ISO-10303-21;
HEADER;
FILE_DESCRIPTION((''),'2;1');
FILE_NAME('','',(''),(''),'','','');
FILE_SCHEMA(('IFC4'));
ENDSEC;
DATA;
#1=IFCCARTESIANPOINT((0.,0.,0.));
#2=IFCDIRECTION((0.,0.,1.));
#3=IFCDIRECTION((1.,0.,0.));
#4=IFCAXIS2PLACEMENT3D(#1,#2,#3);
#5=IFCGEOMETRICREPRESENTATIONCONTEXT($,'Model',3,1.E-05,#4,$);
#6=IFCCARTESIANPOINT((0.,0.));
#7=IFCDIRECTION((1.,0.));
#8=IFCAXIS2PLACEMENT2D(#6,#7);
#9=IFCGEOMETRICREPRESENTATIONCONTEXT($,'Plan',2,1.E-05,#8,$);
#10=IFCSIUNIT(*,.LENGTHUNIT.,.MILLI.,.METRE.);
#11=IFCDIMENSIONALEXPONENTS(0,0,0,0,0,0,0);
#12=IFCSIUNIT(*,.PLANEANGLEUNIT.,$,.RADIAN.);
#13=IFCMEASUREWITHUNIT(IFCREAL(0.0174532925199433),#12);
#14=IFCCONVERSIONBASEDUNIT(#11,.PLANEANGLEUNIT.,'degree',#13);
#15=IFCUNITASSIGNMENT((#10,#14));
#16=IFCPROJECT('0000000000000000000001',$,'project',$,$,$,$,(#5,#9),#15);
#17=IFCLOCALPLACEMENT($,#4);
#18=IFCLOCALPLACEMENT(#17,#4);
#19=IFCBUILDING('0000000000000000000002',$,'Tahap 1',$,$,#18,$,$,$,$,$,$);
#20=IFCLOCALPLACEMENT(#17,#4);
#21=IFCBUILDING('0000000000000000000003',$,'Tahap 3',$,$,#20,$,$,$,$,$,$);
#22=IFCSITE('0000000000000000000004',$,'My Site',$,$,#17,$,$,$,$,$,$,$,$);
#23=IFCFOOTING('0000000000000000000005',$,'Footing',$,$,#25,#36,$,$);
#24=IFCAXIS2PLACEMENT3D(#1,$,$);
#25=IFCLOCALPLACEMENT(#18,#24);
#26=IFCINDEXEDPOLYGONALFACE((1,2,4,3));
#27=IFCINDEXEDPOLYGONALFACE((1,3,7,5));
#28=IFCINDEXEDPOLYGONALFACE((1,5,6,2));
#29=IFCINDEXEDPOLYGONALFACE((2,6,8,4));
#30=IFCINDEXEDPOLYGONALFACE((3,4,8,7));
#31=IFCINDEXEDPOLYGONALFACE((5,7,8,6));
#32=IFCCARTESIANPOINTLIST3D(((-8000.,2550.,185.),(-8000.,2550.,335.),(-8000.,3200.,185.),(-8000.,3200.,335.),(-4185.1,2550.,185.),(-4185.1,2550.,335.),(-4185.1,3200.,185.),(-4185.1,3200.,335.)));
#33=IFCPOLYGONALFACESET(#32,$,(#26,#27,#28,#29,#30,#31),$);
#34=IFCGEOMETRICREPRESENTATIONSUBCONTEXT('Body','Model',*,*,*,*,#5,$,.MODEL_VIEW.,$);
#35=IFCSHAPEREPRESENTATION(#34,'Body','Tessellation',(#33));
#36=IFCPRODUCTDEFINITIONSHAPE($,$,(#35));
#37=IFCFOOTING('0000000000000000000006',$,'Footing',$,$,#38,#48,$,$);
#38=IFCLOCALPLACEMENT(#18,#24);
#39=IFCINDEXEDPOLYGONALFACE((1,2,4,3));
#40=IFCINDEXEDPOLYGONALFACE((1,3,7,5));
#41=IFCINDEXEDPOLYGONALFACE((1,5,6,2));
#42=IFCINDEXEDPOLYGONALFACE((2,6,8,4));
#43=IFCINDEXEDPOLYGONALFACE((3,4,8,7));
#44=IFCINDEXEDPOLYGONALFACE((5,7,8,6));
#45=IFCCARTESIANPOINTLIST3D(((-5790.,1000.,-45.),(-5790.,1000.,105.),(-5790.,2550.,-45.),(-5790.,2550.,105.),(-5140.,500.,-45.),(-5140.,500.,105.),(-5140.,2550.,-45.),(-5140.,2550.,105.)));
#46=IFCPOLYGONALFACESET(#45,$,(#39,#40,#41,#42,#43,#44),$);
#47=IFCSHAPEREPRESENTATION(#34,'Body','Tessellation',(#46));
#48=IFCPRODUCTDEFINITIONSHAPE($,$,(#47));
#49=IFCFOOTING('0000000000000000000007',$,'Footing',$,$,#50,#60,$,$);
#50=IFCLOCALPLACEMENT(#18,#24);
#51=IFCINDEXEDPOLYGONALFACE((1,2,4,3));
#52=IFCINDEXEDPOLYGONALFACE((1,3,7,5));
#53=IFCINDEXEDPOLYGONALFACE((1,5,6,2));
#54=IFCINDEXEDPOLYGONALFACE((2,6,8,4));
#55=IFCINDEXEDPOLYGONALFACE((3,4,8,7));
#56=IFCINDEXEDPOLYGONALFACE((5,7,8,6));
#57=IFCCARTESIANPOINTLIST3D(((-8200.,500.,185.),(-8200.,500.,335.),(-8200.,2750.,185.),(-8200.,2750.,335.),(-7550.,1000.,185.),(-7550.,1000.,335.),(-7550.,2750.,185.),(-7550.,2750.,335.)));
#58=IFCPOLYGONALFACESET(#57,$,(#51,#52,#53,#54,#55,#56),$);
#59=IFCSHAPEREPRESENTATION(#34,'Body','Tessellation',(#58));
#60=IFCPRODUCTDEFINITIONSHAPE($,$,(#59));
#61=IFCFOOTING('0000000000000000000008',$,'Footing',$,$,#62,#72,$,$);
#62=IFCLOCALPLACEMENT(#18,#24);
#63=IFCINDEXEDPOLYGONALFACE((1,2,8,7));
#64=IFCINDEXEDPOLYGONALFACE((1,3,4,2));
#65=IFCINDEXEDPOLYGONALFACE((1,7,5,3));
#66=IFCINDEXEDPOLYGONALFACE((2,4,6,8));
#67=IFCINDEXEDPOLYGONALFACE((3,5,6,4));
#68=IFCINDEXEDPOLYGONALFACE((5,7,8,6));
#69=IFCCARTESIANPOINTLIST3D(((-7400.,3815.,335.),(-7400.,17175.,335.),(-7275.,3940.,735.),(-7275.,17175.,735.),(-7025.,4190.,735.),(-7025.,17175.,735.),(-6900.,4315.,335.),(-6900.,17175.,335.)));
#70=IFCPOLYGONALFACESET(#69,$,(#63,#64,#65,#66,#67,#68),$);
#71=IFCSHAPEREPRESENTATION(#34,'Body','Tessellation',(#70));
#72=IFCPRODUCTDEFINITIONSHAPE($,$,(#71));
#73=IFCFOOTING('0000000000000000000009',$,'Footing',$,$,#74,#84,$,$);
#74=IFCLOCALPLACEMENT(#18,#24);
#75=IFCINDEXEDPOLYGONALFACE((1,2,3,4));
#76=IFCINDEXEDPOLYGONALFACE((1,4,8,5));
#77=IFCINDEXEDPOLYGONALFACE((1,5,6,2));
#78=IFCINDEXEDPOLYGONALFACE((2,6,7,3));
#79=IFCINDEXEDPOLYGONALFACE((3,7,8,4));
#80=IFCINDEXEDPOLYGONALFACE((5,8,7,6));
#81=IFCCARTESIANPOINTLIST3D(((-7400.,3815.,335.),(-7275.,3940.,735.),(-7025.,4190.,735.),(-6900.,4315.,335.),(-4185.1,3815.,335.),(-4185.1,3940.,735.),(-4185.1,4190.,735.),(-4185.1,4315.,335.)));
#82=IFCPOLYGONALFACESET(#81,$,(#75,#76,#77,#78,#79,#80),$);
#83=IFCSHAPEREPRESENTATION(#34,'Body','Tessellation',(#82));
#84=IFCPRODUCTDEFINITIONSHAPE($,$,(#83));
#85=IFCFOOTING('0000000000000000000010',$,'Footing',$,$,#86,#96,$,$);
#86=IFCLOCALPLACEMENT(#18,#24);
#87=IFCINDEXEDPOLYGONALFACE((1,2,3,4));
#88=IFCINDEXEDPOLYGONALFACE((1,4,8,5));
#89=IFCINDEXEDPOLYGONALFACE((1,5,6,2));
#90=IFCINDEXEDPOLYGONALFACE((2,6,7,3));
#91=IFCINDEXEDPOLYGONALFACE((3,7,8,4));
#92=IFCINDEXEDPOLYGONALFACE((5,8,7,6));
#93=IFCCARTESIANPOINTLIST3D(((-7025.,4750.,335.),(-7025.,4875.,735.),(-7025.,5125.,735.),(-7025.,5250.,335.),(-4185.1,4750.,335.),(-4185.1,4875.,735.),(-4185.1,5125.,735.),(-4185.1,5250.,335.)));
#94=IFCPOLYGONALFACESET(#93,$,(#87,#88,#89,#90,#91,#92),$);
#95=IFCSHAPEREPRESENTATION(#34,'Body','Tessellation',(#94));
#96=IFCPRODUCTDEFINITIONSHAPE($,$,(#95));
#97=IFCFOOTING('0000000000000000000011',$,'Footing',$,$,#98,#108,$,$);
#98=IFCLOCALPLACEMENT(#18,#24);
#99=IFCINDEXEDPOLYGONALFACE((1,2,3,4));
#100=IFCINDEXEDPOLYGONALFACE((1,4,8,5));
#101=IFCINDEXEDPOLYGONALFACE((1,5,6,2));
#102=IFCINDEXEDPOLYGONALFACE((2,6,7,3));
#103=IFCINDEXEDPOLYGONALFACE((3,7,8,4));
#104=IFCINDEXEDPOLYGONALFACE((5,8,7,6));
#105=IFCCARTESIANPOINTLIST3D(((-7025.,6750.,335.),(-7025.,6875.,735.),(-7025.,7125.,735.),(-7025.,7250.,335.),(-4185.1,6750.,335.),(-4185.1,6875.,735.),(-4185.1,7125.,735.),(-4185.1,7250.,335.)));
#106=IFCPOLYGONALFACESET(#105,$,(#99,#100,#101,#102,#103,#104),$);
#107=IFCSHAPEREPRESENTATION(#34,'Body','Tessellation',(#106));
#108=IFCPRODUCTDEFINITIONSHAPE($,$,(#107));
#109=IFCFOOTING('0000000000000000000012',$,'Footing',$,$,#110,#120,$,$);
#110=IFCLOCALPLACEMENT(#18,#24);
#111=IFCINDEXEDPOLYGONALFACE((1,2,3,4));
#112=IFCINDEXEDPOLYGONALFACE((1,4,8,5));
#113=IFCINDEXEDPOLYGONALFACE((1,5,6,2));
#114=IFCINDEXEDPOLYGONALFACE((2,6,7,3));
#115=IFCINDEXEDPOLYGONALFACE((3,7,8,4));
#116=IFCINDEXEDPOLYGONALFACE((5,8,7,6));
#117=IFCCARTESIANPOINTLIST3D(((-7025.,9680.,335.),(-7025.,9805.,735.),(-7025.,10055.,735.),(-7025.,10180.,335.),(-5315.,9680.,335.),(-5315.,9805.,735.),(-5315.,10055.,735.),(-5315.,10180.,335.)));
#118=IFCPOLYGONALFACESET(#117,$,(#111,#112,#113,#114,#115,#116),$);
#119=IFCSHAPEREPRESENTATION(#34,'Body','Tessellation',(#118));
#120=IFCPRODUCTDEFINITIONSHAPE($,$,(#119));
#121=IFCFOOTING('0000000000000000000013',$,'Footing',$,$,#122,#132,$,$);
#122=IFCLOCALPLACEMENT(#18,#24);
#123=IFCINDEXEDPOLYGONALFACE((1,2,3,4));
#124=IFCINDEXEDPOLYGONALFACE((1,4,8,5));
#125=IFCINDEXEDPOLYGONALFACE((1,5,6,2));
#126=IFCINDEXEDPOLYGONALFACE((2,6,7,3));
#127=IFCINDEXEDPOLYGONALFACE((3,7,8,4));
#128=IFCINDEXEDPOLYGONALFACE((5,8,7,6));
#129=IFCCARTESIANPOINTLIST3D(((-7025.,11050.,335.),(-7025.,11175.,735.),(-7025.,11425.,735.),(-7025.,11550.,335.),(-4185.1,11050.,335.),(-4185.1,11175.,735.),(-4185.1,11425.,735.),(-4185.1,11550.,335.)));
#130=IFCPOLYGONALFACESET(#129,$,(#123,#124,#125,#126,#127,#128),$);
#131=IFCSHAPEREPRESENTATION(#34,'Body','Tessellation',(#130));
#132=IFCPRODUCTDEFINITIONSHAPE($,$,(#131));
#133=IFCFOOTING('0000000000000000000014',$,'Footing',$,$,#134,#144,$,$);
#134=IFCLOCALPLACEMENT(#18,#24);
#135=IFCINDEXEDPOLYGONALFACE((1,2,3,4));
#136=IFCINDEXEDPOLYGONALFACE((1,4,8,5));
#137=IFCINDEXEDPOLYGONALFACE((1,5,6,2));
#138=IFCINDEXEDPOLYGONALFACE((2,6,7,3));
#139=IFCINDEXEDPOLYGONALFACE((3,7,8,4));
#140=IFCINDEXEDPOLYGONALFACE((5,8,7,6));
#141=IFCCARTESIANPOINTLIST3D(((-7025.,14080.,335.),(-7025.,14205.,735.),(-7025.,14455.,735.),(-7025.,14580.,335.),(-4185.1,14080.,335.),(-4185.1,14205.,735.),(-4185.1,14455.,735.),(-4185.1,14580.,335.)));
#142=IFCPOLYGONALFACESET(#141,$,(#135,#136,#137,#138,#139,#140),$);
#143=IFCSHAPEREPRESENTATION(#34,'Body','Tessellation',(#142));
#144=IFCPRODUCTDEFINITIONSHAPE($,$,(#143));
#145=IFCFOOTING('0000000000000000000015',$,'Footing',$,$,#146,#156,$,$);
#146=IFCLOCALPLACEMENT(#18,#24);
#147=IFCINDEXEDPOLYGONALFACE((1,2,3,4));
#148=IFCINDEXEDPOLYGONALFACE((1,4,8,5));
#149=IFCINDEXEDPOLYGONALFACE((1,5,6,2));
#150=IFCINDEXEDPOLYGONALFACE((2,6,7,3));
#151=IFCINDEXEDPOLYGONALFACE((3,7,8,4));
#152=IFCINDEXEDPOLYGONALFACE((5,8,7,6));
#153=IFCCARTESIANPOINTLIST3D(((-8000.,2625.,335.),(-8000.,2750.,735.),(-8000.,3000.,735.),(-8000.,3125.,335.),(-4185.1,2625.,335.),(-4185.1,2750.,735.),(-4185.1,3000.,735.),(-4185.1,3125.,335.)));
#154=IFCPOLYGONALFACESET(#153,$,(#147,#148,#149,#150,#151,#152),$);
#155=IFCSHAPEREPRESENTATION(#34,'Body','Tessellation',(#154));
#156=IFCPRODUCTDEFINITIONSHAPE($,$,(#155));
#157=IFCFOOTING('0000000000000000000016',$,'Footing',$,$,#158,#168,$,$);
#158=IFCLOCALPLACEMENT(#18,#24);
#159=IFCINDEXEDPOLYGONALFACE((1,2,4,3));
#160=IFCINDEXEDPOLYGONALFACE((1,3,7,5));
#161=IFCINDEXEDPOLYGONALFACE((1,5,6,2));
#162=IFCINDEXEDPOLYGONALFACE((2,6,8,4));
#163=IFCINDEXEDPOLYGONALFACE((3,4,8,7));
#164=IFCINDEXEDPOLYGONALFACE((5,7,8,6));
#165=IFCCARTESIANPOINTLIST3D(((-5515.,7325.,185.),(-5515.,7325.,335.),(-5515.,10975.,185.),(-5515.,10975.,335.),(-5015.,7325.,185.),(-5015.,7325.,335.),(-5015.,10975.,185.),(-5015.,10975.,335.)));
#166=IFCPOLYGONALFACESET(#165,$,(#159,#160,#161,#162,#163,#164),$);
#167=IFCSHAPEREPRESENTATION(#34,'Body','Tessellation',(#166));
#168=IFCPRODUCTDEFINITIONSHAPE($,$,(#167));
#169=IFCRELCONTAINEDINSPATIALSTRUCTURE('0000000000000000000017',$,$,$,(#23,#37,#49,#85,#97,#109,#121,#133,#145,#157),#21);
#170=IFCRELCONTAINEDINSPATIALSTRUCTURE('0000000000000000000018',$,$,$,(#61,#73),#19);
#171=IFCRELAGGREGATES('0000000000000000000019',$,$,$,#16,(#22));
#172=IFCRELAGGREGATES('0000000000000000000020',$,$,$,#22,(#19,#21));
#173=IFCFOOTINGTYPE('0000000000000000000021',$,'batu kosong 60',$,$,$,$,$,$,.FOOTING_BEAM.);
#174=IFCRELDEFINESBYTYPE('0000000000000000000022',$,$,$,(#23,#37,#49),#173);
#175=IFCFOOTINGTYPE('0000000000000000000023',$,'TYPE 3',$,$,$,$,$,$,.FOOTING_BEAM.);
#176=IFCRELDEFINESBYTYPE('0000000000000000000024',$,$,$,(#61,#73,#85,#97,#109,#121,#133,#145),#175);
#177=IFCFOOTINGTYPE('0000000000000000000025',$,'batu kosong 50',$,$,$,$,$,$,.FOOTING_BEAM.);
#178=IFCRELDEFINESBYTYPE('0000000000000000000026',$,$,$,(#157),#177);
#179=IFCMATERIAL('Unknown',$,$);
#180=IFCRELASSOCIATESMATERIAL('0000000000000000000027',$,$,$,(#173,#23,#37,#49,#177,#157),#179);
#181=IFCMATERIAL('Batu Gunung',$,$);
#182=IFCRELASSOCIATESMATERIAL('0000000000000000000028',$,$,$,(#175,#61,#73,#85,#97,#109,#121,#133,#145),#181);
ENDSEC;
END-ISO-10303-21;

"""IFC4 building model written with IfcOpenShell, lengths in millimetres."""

from ifc_helpers import new_model, entity, si_unit, converted_unit, frame, origin_with_axes, origin_2d_with_axis, place, context, subcontext, project, spatial, indexed_curve, rectangle, outline, extrude, clip, halfspace, material, material_profile, profile_set, profile_usage, type_object, element, save


model = new_model("IFC4")

# Units and contexts
model_context = context("Model", 3, precision=1e-05, world=origin_with_axes())
plan_context = context("Plan", 2, precision=1e-05, world=origin_2d_with_axis())
body_context = subcontext(model_context, "Body", "Model", "MODEL_VIEW")
ifc_project = project(units=[si_unit("LENGTHUNIT", "METRE", prefix="MILLI"), converted_unit("PLANEANGLEUNIT", "degree", entity("IfcReal", 0.0174532925199433), si_unit("PLANEANGLEUNIT", "RADIAN"), dimensions=[0, 0, 0, 0, 0, 0, 0])], contexts=[model_context, plan_context])

# Site, building
site_placement = place(None, origin_with_axes())
site = spatial("IfcSite", under=ifc_project, at=site_placement, Name="My Site")
building_1_placement = place(site_placement, origin_with_axes())
building_1 = spatial("IfcBuilding", under=site, at=building_1_placement, Name="Tahap 1")

# Shared definitions
ifc_material_1 = material(Name="Batu Gunung")

# Shared definitions
building_2_placement = place(site_placement, origin_with_axes())
building_2 = spatial("IfcBuilding", under=site, at=building_2_placement, Name="Tahap 3")

# Footings
ifc_material_2 = material(Name="Unknown")
ifc_material_profile_1 = material_profile(ifc_material_2, rectangle(XDim=650.0, YDim=150.0, kind="CURVE"))
ifc_profile_set_1 = profile_set([ifc_material_profile_1])
footing_type_1 = type_object("IfcFootingType", Name="batu kosong 60", PredefinedType="FOOTING_BEAM", material=ifc_profile_set_1)
ifc_profile_usage_1 = profile_usage(ifc_profile_set_1, cardinal=8)
footing_1_placement = place(building_2_placement, frame((-8000.0, 2875.0, 335.0), z_axis=(1.0, 0.0, 0.0), x_axis=(0.0, 1.0, 0.0)))
element("IfcFooting", 1, at=footing_1_placement, inside=building_2, type_object=footing_type_1, material=ifc_profile_usage_1, Name="Footing", context=body_context, shape_type="SweptSolid", body=[
    extrude(rectangle(XDim=650.0, YDim=150.0, kind="CURVE"), frame((0.0, -75.0, 0.0), z_axis=(0.0, 0.0, 1.0), x_axis=(1.0, 0.0, 0.0)), (0.0, 0.0, 1.0), 3814.9),
])
ifc_profile_usage_2 = profile_usage(ifc_profile_set_1, cardinal=8)
footing_2_placement = place(building_2_placement, frame((-5465.0, 500.0, 105.0), z_axis=(0.000001, 1.0, 0.0), x_axis=(-1.0, 0.000001, 0.0)))
element("IfcFooting", 2, at=footing_2_placement, inside=building_2, type_object=footing_type_1, material=ifc_profile_usage_2, Name="Footing", context=body_context, shape_type="Clipping", body=[
    clip(extrude(rectangle(XDim=650.0, YDim=150.0, kind="CURVE"), frame((0.0, -75.0, 0.0), z_axis=(0.0, 0.0, 1.0), x_axis=(1.0, 0.0, 0.0)), (0.0, 0.0, 1.0), 2050.0), halfspace(frame((-325.0, -105.0, 0.0), z_axis=(0.60971, 0.0, -0.792624), x_axis=(0.0, -1.0, 0.0)), False)),
])
ifc_profile_usage_3 = profile_usage(ifc_profile_set_1, cardinal=8)
footing_3_placement = place(building_2_placement, frame((-7875.0, 2750.0, 335.0), z_axis=(0.0, -1.0, 0.0), x_axis=(1.0, 0.0, 0.0)))
element("IfcFooting", 3, at=footing_3_placement, inside=building_2, type_object=footing_type_1, material=ifc_profile_usage_3, Name="Footing", context=body_context, shape_type="Clipping", body=[
    clip(extrude(rectangle(XDim=650.0, YDim=150.0, kind="CURVE"), frame((0.0, -75.0, 0.0), z_axis=(0.0, 0.0, 1.0), x_axis=(1.0, 0.0, 0.0)), (0.0, 0.0, 1.0), 2250.0), halfspace(frame((-325.0, -335.0, 2250.0), z_axis=(0.609712, 0.0, 0.792623), x_axis=(0.0, -1.0, 0.0)), False)),
])
ifc_material_profile_2 = material_profile(ifc_material_1, outline(indexed_curve([(-125.0, 0.0), (125.0, 0.0), (250.0, -400.0), (-250.0, -400.0), (-125.0, 0.0)])))
ifc_profile_set_2 = profile_set([ifc_material_profile_2])
ifc_profile_usage_4 = profile_usage(ifc_profile_set_2)
footing_type_2 = type_object("IfcFootingType", Name="TYPE 3", PredefinedType="FOOTING_BEAM", material=ifc_profile_set_2)
footing_4_placement = place(building_1_placement, frame((-7150.0, 3815.0, 735.0), z_axis=(0.0, 1.0, 0.0), x_axis=(-1.0, 0.0, 0.0)))
element("IfcFooting", 4, at=footing_4_placement, inside=building_1, type_object=footing_type_2, material=ifc_profile_usage_4, Name="Footing", context=body_context, shape_type="Clipping", body=[
    clip(extrude(outline(indexed_curve([(-125.0, 0.0), (125.0, 0.0), (250.0, -400.0), (-250.0, -400.0), (-125.0, 0.0)])), origin_with_axes(), (0.0, 0.0, 1.0), 13360.0), halfspace(frame((250.0, -735.0, 0.0), z_axis=(-0.707106, 0.0, -0.707107), x_axis=(0.0, 1.0, 0.0)), False)),
])
ifc_profile_usage_5 = profile_usage(ifc_profile_set_2)
footing_5_placement = place(building_1_placement, frame((-7400.0, 4065.0, 735.0), z_axis=(1.0, 0.0, 0.0), x_axis=(0.0, 1.0, 0.0)))
element("IfcFooting", 5, at=footing_5_placement, inside=building_1, type_object=footing_type_2, material=ifc_profile_usage_5, Name="Footing", context=body_context, shape_type="Clipping", body=[
    clip(extrude(outline(indexed_curve([(-125.0, 0.0), (125.0, 0.0), (250.0, -400.0), (-250.0, -400.0), (-125.0, 0.0)])), origin_with_axes(), (0.0, 0.0, 1.0), 3214.9), halfspace(frame((-250.0, -735.0, 0.0), z_axis=(0.707107, 0.0, -0.707106), x_axis=(0.0, -1.0, 0.0)), False)),
])
ifc_profile_usage_6 = profile_usage(ifc_profile_set_2)
footing_6_placement = place(building_2_placement, frame((-7025.0, 5000.0, 735.0), z_axis=(1.0, 0.0, 0.0), x_axis=(0.0, 1.0, 0.0)))
element("IfcFooting", 6, at=footing_6_placement, inside=building_2, type_object=footing_type_2, material=ifc_profile_usage_6, Name="Footing", context=body_context, shape_type="SweptSolid", body=[
    extrude(outline(indexed_curve([(-125.0, 0.0), (125.0, 0.0), (250.0, -400.0), (-250.0, -400.0), (-125.0, 0.0)])), origin_with_axes(), (0.0, 0.0, 1.0), 2839.9),
])
ifc_profile_usage_7 = profile_usage(ifc_profile_set_2)
footing_7_placement = place(building_2_placement, frame((-7025.0, 7000.0, 735.0), z_axis=(1.0, 0.0, 0.0), x_axis=(0.0, 1.0, 0.0)))
element("IfcFooting", 7, at=footing_7_placement, inside=building_2, type_object=footing_type_2, material=ifc_profile_usage_7, Name="Footing", context=body_context, shape_type="SweptSolid", body=[
    extrude(outline(indexed_curve([(-125.0, 0.0), (125.0, 0.0), (250.0, -400.0), (-250.0, -400.0), (-125.0, 0.0)])), origin_with_axes(), (0.0, 0.0, 1.0), 2839.9),
])
ifc_profile_usage_8 = profile_usage(ifc_profile_set_2)
footing_8_placement = place(building_2_placement, frame((-7025.0, 9930.0, 735.0), z_axis=(1.0, 0.0, 0.0), x_axis=(0.0, 1.0, 0.0)))
element("IfcFooting", 8, at=footing_8_placement, inside=building_2, type_object=footing_type_2, material=ifc_profile_usage_8, Name="Footing", context=body_context, shape_type="SweptSolid", body=[
    extrude(outline(indexed_curve([(-125.0, 0.0), (125.0, 0.0), (250.0, -400.0), (-250.0, -400.0), (-125.0, 0.0)])), origin_with_axes(), (0.0, 0.0, 1.0), 1710.0),
])
ifc_profile_usage_9 = profile_usage(ifc_profile_set_2)
footing_9_placement = place(building_2_placement, frame((-7025.0, 11300.0, 735.0), z_axis=(1.0, 0.0, 0.0), x_axis=(0.0, 1.0, 0.0)))
element("IfcFooting", 9, at=footing_9_placement, inside=building_2, type_object=footing_type_2, material=ifc_profile_usage_9, Name="Footing", context=body_context, shape_type="SweptSolid", body=[
    extrude(outline(indexed_curve([(-125.0, 0.0), (125.0, 0.0), (250.0, -400.0), (-250.0, -400.0), (-125.0, 0.0)])), origin_with_axes(), (0.0, 0.0, 1.0), 2839.9),
])
ifc_profile_usage_10 = profile_usage(ifc_profile_set_2)
footing_10_placement = place(building_2_placement, frame((-7025.0, 14330.0, 735.0), z_axis=(1.0, 0.0, 0.0), x_axis=(0.0, 1.0, 0.0)))
element("IfcFooting", 10, at=footing_10_placement, inside=building_2, type_object=footing_type_2, material=ifc_profile_usage_10, Name="Footing", context=body_context, shape_type="SweptSolid", body=[
    extrude(outline(indexed_curve([(-125.0, 0.0), (125.0, 0.0), (250.0, -400.0), (-250.0, -400.0), (-125.0, 0.0)])), origin_with_axes(), (0.0, 0.0, 1.0), 2839.9),
])
ifc_profile_usage_11 = profile_usage(ifc_profile_set_2)
footing_11_placement = place(building_2_placement, frame((-8000.0, 2875.0, 735.0), z_axis=(1.0, 0.0, 0.0), x_axis=(0.0, 1.0, 0.0)))
element("IfcFooting", 11, at=footing_11_placement, inside=building_2, type_object=footing_type_2, material=ifc_profile_usage_11, Name="Footing", context=body_context, shape_type="SweptSolid", body=[
    extrude(outline(indexed_curve([(-125.0, 0.0), (125.0, 0.0), (250.0, -400.0), (-250.0, -400.0), (-125.0, 0.0)])), origin_with_axes(), (0.0, 0.0, 1.0), 3814.9),
])
ifc_material_profile_3 = material_profile(ifc_material_2, rectangle(XDim=500.0, YDim=150.0, kind="CURVE"))
ifc_profile_set_3 = profile_set([ifc_material_profile_3])
ifc_profile_usage_12 = profile_usage(ifc_profile_set_3)
footing_type_3 = type_object("IfcFootingType", Name="batu kosong 50", PredefinedType="FOOTING_BEAM", material=ifc_profile_set_3)
footing_12_placement = place(building_2_placement, frame((-5265.0, 7325.0, 260.0), z_axis=(0.0, 1.0, 0.0), x_axis=(-1.0, 0.0, 0.0)))
element("IfcFooting", 12, at=footing_12_placement, inside=building_2, type_object=footing_type_3, material=ifc_profile_usage_12, Name="Footing", context=body_context, shape_type="SweptSolid", body=[
    extrude(rectangle(XDim=500.0, YDim=150.0, kind="CURVE"), origin_with_axes(), (0.0, 0.0, 1.0), 3650.0),
])

save(model, "model.ifc")
